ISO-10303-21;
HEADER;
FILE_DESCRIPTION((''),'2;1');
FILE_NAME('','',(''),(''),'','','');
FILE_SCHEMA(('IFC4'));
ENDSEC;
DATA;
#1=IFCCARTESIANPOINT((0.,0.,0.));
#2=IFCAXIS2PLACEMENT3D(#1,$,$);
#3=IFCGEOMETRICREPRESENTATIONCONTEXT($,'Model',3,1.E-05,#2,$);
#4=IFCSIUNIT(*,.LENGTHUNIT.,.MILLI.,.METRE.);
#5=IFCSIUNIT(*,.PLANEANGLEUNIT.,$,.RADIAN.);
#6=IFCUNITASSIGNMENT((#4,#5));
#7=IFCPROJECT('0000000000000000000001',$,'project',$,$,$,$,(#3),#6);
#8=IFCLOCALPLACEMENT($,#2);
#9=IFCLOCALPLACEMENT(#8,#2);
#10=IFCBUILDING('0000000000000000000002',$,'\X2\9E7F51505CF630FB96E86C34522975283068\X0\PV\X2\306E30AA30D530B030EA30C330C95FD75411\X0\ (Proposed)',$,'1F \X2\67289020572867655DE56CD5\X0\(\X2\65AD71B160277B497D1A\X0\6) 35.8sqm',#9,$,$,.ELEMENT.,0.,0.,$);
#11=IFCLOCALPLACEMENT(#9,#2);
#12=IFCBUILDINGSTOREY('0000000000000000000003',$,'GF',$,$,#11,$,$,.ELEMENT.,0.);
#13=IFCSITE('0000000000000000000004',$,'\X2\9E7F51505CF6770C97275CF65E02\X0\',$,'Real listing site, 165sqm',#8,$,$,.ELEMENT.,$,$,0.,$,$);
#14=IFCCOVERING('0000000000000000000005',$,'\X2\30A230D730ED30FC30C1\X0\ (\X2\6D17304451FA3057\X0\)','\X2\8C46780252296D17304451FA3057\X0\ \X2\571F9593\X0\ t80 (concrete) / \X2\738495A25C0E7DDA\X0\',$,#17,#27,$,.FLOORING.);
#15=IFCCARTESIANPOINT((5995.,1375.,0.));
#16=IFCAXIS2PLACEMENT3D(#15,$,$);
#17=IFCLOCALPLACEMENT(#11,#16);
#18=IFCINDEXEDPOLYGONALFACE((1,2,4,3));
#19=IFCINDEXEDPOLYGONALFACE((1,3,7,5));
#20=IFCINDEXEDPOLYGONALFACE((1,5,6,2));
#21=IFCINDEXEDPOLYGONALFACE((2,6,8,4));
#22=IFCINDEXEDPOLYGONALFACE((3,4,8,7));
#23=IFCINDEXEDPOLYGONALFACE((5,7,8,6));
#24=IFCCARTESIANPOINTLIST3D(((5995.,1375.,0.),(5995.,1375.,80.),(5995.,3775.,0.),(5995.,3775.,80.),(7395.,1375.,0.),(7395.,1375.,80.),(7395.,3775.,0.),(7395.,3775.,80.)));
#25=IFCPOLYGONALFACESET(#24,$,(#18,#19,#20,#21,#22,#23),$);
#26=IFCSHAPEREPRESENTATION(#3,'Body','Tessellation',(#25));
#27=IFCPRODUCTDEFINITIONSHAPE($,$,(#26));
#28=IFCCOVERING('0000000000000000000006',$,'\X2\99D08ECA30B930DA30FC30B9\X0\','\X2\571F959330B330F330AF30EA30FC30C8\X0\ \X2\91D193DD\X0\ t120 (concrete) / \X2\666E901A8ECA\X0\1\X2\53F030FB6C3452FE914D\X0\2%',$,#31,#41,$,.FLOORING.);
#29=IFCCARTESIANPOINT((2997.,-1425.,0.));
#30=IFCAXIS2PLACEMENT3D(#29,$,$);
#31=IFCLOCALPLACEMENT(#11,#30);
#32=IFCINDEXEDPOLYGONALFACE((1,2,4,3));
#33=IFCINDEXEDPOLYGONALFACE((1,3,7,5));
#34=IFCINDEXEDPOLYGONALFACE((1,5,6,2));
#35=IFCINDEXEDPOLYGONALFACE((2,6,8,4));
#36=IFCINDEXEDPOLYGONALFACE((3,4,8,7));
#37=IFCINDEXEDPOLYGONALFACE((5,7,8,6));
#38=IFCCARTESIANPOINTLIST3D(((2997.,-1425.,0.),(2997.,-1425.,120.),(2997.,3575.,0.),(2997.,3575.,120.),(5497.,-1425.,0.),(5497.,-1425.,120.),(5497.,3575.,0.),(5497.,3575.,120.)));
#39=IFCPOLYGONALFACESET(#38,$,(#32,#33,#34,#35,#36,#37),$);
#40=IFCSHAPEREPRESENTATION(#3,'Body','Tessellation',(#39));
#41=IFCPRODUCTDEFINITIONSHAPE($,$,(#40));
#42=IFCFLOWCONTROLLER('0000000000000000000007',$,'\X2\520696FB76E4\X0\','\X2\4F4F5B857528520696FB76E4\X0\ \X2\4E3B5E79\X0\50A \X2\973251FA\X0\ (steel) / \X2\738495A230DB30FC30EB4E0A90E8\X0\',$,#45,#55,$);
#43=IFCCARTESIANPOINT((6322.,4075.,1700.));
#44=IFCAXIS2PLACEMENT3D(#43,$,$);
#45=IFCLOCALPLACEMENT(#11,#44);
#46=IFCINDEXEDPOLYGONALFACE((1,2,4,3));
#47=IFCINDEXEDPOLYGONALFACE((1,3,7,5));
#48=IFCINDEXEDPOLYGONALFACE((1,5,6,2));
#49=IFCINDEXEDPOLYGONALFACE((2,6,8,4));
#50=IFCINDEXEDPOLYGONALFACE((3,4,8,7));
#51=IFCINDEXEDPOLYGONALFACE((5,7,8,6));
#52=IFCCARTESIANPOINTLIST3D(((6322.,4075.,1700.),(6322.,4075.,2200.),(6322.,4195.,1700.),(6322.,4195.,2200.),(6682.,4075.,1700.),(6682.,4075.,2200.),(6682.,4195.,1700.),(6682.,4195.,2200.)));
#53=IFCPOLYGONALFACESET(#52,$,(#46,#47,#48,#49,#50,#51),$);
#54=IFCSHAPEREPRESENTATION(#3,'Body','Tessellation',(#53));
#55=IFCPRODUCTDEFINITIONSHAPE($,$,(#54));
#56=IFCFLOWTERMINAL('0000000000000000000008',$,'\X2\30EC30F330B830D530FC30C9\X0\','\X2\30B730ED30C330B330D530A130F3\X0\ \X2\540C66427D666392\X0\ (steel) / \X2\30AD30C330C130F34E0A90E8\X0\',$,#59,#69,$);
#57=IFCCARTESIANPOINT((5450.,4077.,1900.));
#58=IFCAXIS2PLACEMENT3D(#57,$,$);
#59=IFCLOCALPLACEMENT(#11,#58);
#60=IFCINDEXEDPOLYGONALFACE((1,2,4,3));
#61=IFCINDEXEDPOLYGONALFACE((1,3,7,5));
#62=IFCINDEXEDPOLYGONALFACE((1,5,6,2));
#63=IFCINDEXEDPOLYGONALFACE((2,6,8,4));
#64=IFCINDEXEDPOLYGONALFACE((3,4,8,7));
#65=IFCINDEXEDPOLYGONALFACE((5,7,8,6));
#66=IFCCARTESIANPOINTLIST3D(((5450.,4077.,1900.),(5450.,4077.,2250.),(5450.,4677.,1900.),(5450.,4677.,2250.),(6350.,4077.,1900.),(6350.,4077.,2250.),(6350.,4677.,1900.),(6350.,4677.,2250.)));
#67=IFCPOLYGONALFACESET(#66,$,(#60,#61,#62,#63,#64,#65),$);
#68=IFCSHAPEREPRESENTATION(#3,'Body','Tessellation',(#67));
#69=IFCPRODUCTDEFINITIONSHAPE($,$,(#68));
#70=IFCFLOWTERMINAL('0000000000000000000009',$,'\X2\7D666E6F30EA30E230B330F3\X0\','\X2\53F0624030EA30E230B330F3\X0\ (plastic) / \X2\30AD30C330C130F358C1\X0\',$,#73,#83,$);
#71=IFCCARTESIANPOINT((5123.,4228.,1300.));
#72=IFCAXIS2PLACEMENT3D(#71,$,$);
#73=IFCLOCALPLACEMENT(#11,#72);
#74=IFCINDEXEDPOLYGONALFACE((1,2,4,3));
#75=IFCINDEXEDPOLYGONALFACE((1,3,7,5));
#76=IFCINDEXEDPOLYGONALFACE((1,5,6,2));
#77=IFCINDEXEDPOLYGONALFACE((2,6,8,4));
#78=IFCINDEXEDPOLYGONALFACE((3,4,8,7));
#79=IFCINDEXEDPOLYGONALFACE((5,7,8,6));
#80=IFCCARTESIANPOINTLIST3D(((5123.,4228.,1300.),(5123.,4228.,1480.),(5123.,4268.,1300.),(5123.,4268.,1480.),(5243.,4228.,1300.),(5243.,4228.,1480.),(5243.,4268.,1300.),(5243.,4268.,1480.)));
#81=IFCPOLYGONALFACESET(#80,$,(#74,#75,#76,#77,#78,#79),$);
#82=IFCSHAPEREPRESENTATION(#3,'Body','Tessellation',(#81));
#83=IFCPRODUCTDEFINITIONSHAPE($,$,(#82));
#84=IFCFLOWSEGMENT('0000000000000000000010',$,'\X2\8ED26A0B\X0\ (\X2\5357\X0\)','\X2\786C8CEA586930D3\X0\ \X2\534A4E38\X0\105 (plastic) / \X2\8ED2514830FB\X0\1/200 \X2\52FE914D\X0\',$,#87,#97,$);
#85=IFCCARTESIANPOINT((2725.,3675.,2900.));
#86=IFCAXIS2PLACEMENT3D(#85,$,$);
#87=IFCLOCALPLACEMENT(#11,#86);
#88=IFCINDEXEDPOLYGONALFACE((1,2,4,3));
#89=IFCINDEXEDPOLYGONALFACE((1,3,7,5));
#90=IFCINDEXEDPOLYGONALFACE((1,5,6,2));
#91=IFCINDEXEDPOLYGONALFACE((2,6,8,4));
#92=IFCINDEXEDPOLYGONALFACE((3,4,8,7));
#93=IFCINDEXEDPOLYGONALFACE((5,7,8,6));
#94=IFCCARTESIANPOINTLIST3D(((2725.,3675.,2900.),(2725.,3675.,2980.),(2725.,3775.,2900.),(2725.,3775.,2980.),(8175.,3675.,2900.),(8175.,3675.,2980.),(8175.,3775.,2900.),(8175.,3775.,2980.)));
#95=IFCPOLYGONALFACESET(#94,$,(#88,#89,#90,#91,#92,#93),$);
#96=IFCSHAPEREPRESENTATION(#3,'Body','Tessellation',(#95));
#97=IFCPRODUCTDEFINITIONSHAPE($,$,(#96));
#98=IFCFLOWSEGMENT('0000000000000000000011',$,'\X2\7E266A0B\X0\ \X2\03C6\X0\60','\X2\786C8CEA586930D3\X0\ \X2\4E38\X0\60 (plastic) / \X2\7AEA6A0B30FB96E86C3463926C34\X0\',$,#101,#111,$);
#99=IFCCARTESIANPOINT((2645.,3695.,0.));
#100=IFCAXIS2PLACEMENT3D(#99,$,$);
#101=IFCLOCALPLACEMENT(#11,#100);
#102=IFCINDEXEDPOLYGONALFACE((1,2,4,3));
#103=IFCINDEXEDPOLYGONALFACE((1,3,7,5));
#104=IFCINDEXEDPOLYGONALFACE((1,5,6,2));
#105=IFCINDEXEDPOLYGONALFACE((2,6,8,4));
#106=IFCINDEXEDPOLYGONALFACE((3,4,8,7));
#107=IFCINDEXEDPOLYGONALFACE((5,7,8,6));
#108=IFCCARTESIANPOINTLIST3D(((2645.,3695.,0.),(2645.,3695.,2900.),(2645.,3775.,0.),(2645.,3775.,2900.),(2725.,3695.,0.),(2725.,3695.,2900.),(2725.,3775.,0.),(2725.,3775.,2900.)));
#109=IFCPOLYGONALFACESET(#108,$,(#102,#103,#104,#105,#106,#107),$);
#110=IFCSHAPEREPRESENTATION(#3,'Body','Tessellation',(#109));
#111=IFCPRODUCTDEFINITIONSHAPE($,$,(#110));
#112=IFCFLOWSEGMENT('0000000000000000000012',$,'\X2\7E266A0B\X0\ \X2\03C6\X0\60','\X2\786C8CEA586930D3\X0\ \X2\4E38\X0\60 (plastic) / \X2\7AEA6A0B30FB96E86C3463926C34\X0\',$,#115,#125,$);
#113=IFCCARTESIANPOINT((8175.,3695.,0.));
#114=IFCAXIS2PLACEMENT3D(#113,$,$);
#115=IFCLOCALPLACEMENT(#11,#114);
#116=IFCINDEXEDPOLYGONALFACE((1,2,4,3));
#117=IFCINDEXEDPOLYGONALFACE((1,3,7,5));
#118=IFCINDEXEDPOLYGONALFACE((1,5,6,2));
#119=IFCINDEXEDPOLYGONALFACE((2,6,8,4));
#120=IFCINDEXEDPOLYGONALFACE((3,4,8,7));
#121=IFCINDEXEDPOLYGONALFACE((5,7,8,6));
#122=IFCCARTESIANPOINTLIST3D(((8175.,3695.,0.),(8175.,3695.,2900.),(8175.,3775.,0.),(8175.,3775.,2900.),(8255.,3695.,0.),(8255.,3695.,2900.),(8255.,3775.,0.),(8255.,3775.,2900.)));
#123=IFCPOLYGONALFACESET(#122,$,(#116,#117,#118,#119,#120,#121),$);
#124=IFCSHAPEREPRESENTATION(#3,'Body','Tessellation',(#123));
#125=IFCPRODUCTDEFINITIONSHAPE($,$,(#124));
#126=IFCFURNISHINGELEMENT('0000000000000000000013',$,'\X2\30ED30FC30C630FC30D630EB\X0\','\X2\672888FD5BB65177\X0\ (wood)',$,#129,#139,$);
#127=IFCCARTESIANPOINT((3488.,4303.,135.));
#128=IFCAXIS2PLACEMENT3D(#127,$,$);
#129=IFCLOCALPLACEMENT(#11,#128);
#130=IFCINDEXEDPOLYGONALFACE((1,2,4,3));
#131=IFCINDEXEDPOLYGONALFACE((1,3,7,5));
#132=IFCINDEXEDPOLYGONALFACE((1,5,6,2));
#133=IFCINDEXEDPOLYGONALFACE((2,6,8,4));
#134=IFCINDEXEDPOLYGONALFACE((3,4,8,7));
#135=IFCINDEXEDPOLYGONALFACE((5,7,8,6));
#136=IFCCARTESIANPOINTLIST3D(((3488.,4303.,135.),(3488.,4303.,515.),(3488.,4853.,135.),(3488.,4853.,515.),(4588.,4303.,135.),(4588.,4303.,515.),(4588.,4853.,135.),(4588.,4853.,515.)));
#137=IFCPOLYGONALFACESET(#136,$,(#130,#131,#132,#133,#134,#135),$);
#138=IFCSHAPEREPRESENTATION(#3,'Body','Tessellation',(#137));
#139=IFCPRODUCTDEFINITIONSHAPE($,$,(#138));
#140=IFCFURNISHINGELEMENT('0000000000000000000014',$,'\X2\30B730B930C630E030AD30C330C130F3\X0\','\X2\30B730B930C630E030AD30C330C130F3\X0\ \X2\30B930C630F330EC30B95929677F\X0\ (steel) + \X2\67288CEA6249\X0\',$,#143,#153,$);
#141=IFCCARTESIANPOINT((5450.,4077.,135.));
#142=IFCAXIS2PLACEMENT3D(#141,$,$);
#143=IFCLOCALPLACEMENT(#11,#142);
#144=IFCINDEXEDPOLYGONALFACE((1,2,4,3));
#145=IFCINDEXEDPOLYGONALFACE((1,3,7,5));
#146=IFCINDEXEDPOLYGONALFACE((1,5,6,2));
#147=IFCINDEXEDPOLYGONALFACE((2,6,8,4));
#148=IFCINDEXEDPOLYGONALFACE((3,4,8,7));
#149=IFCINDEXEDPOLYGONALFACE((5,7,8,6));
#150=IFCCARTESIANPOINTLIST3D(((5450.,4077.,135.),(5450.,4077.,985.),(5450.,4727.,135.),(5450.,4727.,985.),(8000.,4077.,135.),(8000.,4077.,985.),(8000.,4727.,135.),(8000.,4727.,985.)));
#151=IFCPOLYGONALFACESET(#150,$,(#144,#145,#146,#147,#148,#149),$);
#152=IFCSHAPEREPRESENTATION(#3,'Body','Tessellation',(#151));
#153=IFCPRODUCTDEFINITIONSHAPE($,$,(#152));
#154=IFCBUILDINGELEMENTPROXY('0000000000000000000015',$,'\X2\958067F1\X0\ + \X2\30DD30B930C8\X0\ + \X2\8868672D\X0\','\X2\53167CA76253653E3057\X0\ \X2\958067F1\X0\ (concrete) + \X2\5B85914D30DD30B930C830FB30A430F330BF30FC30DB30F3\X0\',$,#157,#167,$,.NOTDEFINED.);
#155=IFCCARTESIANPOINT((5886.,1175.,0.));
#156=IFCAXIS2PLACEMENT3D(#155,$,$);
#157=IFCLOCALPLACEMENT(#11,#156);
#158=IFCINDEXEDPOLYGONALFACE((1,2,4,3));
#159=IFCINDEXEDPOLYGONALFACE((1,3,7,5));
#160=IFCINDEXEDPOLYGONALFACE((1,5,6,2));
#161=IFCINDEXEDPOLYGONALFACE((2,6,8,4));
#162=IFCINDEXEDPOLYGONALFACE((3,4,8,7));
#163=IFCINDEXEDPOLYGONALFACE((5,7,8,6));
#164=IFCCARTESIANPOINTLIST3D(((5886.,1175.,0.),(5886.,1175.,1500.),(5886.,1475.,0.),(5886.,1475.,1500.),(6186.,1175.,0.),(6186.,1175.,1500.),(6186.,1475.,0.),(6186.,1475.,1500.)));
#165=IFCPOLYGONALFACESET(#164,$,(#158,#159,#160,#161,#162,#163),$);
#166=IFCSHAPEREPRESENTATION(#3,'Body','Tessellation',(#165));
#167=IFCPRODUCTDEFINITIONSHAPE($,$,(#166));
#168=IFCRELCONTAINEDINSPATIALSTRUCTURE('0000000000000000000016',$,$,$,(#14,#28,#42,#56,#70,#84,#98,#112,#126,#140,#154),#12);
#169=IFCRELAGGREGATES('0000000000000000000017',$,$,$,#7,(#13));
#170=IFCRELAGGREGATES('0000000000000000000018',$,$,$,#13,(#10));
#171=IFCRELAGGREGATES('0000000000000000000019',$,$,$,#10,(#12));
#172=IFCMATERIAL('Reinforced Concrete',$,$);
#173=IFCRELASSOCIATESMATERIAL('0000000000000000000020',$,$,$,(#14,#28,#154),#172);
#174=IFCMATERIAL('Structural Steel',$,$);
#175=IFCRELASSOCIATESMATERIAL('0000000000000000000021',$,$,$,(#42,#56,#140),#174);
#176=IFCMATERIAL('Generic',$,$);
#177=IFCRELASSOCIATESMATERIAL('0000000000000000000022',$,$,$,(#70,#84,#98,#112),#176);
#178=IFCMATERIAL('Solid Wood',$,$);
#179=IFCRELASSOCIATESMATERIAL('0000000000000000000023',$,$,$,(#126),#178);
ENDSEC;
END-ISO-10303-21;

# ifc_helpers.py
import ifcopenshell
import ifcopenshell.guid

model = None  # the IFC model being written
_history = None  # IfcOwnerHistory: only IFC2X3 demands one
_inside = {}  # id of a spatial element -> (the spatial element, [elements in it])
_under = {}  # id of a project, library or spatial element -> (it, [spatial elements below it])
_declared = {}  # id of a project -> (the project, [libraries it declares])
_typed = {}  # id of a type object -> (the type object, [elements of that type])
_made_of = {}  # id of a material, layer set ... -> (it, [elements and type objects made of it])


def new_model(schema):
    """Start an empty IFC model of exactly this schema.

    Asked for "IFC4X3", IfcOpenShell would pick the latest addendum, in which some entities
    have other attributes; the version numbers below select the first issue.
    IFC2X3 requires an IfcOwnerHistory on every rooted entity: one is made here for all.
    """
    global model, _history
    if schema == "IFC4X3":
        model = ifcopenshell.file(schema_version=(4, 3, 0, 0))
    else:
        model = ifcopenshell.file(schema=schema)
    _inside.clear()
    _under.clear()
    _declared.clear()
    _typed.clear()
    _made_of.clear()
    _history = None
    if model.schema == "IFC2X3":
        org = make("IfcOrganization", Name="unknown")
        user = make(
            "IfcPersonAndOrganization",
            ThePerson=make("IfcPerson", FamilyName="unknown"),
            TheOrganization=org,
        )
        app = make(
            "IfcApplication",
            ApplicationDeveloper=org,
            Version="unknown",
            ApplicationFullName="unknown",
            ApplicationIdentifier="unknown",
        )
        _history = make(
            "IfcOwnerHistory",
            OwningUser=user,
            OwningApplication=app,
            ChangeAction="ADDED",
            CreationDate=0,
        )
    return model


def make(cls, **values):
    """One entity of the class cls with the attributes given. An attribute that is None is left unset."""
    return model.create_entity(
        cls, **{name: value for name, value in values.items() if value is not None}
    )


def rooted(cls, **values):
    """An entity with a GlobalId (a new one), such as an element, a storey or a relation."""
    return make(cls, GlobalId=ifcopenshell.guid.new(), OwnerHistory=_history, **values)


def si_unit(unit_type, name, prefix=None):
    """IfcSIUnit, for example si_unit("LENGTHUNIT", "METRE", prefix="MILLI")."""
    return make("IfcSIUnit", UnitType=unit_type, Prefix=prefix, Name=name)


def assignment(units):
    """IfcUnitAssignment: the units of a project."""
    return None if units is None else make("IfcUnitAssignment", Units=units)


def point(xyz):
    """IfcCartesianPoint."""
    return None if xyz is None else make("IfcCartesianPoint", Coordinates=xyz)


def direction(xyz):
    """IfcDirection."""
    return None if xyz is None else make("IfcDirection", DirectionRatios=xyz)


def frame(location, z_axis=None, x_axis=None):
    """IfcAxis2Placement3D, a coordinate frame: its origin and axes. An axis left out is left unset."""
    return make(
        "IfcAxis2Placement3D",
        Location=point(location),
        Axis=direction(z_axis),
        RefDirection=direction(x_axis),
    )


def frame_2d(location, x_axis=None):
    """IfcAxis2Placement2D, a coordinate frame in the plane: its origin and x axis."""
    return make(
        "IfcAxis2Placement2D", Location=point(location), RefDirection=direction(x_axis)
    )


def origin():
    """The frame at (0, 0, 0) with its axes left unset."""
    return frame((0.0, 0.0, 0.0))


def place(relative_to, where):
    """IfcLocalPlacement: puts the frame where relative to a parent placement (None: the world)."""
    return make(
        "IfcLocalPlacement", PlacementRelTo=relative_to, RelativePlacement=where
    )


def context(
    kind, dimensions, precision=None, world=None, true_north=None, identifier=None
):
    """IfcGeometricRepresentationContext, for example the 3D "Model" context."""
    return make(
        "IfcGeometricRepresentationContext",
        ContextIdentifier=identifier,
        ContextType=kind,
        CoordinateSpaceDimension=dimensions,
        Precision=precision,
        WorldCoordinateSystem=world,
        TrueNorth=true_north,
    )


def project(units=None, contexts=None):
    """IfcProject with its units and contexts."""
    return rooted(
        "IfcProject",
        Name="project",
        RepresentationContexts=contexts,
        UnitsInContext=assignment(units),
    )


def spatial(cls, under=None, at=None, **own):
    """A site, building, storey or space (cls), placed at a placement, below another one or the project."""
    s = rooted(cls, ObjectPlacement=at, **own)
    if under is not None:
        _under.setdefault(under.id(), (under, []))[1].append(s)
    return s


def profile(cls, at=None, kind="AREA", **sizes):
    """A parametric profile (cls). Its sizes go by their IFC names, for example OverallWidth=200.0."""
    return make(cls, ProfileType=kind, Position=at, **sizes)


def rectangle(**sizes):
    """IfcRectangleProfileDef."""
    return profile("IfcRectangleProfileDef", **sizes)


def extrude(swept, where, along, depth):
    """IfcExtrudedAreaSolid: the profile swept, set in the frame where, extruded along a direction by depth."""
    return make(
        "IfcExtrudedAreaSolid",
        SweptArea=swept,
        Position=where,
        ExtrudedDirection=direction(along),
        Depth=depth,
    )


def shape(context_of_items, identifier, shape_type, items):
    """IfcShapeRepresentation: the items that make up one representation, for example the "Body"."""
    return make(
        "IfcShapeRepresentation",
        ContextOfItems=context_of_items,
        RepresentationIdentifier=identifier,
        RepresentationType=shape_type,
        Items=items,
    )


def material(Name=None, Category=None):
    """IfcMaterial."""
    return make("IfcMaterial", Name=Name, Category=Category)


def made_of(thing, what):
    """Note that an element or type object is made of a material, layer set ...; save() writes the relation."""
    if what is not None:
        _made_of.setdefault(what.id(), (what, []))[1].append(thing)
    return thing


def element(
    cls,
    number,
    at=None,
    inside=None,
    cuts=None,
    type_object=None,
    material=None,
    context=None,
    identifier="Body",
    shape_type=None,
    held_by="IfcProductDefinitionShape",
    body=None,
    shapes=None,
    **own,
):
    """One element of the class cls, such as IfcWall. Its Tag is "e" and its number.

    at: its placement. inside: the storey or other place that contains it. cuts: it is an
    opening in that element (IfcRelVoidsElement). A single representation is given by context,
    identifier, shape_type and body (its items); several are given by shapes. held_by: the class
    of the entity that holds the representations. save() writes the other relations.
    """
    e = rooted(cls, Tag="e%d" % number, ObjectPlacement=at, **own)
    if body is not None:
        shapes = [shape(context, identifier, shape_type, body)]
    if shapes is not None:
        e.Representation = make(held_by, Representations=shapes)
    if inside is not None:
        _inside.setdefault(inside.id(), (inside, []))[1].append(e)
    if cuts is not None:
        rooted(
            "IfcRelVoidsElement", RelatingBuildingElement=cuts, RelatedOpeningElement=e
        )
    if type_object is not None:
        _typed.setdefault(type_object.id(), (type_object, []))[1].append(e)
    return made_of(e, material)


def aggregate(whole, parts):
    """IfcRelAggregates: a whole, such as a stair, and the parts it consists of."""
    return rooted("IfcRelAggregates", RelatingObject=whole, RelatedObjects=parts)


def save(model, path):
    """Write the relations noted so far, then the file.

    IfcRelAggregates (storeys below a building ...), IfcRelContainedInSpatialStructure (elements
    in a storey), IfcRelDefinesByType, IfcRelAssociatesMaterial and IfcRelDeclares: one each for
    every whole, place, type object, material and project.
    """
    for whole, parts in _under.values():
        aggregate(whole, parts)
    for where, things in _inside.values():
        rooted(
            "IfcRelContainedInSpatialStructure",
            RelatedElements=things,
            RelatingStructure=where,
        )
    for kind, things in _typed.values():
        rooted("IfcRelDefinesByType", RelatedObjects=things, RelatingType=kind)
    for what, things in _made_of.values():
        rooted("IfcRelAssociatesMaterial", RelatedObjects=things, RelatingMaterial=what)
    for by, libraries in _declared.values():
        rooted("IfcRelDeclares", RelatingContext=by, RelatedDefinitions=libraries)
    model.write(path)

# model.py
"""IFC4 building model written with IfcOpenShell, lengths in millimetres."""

from ifc_helpers import new_model, si_unit, frame, frame_2d, origin, place, context, project, spatial, rectangle, extrude, material, element, save


model = new_model("IFC4")

# Units and contexts
model_context = context("Model", 3, precision=1e-05, world=origin())
ifc_project = project(units=[si_unit("LENGTHUNIT", "METRE", prefix="MILLI"), si_unit("PLANEANGLEUNIT", "RADIAN")], contexts=[model_context])

# Site, building, storey
site_placement = place(None, origin())
site = spatial("IfcSite", under=ifc_project, at=site_placement, Name="鹿児島県霧島市", ObjectType="Real listing site, 165sqm", CompositionType="ELEMENT", RefElevation=0.0)
building_placement = place(site_placement, origin())
building = spatial("IfcBuilding", under=site, at=building_placement, Name="鹿児島・雨水利用とPVのオフグリッド志向 (Proposed)", ObjectType="1F 木造在来工法(断熱性等級6) 35.8sqm", CompositionType="ELEMENT", ElevationOfRefHeight=0.0, ElevationOfTerrain=0.0)
storey_placement = place(building_placement, origin())
storey = spatial("IfcBuildingStorey", under=building, at=storey_placement, Name="GF", CompositionType="ELEMENT", Elevation=0.0)

# Shared definitions
ifc_material_1 = material(Name="Solid Wood")

# Shared definitions
ifc_material_2 = material(Name="Reinforced Concrete")

# Shared definitions
ifc_material_3 = material(Name="Structural Steel")

# Coverings
ifc_material_4 = material(Name="Generic")
covering_1_placement = place(storey_placement, frame((5995.0, 1375.0, 0.0)))
element("IfcCovering", 1, at=covering_1_placement, inside=storey, material=ifc_material_2, Name="アプローチ (洗い出し)", Description="豆砂利洗い出し 土間 t80 (concrete) / 玄関導線", PredefinedType="FLOORING", context=model_context, shape_type="SweptSolid", body=[
    extrude(rectangle(XDim=1400.0, YDim=2400.0, at=frame_2d((700.0, 1200.0))), frame((5995.0, 1375.0, 0.0)), (0.0, 0.0, 1.0), 80.0),
])
covering_2_placement = place(storey_placement, frame((2997.0, -1425.0, 0.0)))
element("IfcCovering", 2, at=covering_2_placement, inside=storey, material=ifc_material_2, Name="駐車スペース", Description="土間コンクリート 金鏝 t120 (concrete) / 普通車1台・水勾配2%", PredefinedType="FLOORING", context=model_context, shape_type="SweptSolid", body=[
    extrude(rectangle(XDim=2500.0, YDim=5000.0, at=frame_2d((1250.0, 2500.0))), frame((2997.0, -1425.0, 0.0)), (0.0, 0.0, 1.0), 120.0),
])

# Flow controller
flow_controller_placement = place(storey_placement, frame((6322.0, 4075.0, 1700.0)))
element("IfcFlowController", 3, at=flow_controller_placement, inside=storey, material=ifc_material_3, Name="分電盤", Description="住宅用分電盤 主幹50A 露出 (steel) / 玄関ホール上部", context=model_context, shape_type="SweptSolid", body=[
    extrude(rectangle(XDim=360.0, YDim=120.0, at=frame_2d((180.0, 60.0))), frame((6322.0, 4075.0, 1700.0)), (0.0, 0.0, 1.0), 500.0),
])

# Flow terminals
flow_terminal_1_placement = place(storey_placement, frame((5450.0, 4077.0, 1900.0)))
element("IfcFlowTerminal", 4, at=flow_terminal_1_placement, inside=storey, material=ifc_material_3, Name="レンジフード", Description="シロッコファン 同時給排 (steel) / キッチン上部", context=model_context, shape_type="SweptSolid", body=[
    extrude(rectangle(XDim=900.0, YDim=600.0, at=frame_2d((450.0, 300.0))), frame((5450.0, 4077.0, 1900.0)), (0.0, 0.0, 1.0), 350.0),
])
flow_terminal_2_placement = place(storey_placement, frame((5123.0, 4228.0, 1300.0)))
element("IfcFlowTerminal", 5, at=flow_terminal_2_placement, inside=storey, material=ifc_material_4, Name="給湯リモコン", Description="台所リモコン (plastic) / キッチン壁", context=model_context, shape_type="SweptSolid", body=[
    extrude(rectangle(XDim=120.0, YDim=40.0, at=frame_2d((60.0, 20.0))), frame((5123.0, 4228.0, 1300.0)), (0.0, 0.0, 1.0), 180.0),
])

# Flow segments
flow_segment_1_placement = place(storey_placement, frame((2725.0, 3675.0, 2900.0)))
element("IfcFlowSegment", 6, at=flow_segment_1_placement, inside=storey, material=ifc_material_4, Name="軒樋 (南)", Description="硬質塩ビ 半丸105 (plastic) / 軒先・1/200 勾配", context=model_context, shape_type="SweptSolid", body=[
    extrude(rectangle(XDim=5450.0, YDim=100.0, at=frame_2d((2725.0, 50.0))), frame((2725.0, 3675.0, 2900.0)), (0.0, 0.0, 1.0), 80.0),
])
flow_segment_2_placement = place(storey_placement, frame((2645.0, 3695.0, 0.0)))
element("IfcFlowSegment", 7, at=flow_segment_2_placement, inside=storey, material=ifc_material_4, Name="縦樋 φ60", Description="硬質塩ビ 丸60 (plastic) / 竪樋・雨水排水", context=model_context, shape_type="SweptSolid", body=[
    extrude(rectangle(XDim=80.0, YDim=80.0, at=frame_2d((40.0, 40.0))), frame((2645.0, 3695.0, 0.0)), (0.0, 0.0, 1.0), 2900.0),
])
flow_segment_3_placement = place(storey_placement, frame((8175.0, 3695.0, 0.0)))
element("IfcFlowSegment", 8, at=flow_segment_3_placement, inside=storey, material=ifc_material_4, Name="縦樋 φ60", Description="硬質塩ビ 丸60 (plastic) / 竪樋・雨水排水", context=model_context, shape_type="SweptSolid", body=[
    extrude(rectangle(XDim=80.0, YDim=80.0, at=frame_2d((40.0, 40.0))), frame((8175.0, 3695.0, 0.0)), (0.0, 0.0, 1.0), 2900.0),
])

# Furnishing elements
furnishing_1_placement = place(storey_placement, frame((3488.0, 4303.0, 135.0)))
element("IfcFurnishingElement", 9, at=furnishing_1_placement, inside=storey, material=ifc_material_1, Name="ローテーブル", Description="木製家具 (wood)", context=model_context, shape_type="SweptSolid", body=[
    extrude(rectangle(XDim=1100.0, YDim=550.0, at=frame_2d((550.0, 275.0))), frame((3488.0, 4303.0, 135.0)), (0.0, 0.0, 1.0), 380.0),
])
furnishing_2_placement = place(storey_placement, frame((5450.0, 4077.0, 135.0)))
element("IfcFurnishingElement", 10, at=furnishing_2_placement, inside=storey, material=ifc_material_3, Name="システムキッチン", Description="システムキッチン ステンレス天板 (steel) + 木質扉", context=model_context, shape_type="SweptSolid", body=[
    extrude(rectangle(XDim=2550.0, YDim=650.0, at=frame_2d((1275.0, 325.0))), frame((5450.0, 4077.0, 135.0)), (0.0, 0.0, 1.0), 850.0),
])

# Building element proxy
proxy_placement = place(storey_placement, frame((5886.0, 1175.0, 0.0)))
element("IfcBuildingElementProxy", 11, at=proxy_placement, inside=storey, material=ifc_material_2, Name="門柱 + ポスト + 表札", Description="化粧打放し 門柱 (concrete) + 宅配ポスト・インターホン", PredefinedType="NOTDEFINED", context=model_context, shape_type="SweptSolid", body=[
    extrude(rectangle(XDim=300.0, YDim=300.0, at=frame_2d((150.0, 150.0))), frame((5886.0, 1175.0, 0.0)), (0.0, 0.0, 1.0), 1500.0),
])

save(model, "model.ifc")
